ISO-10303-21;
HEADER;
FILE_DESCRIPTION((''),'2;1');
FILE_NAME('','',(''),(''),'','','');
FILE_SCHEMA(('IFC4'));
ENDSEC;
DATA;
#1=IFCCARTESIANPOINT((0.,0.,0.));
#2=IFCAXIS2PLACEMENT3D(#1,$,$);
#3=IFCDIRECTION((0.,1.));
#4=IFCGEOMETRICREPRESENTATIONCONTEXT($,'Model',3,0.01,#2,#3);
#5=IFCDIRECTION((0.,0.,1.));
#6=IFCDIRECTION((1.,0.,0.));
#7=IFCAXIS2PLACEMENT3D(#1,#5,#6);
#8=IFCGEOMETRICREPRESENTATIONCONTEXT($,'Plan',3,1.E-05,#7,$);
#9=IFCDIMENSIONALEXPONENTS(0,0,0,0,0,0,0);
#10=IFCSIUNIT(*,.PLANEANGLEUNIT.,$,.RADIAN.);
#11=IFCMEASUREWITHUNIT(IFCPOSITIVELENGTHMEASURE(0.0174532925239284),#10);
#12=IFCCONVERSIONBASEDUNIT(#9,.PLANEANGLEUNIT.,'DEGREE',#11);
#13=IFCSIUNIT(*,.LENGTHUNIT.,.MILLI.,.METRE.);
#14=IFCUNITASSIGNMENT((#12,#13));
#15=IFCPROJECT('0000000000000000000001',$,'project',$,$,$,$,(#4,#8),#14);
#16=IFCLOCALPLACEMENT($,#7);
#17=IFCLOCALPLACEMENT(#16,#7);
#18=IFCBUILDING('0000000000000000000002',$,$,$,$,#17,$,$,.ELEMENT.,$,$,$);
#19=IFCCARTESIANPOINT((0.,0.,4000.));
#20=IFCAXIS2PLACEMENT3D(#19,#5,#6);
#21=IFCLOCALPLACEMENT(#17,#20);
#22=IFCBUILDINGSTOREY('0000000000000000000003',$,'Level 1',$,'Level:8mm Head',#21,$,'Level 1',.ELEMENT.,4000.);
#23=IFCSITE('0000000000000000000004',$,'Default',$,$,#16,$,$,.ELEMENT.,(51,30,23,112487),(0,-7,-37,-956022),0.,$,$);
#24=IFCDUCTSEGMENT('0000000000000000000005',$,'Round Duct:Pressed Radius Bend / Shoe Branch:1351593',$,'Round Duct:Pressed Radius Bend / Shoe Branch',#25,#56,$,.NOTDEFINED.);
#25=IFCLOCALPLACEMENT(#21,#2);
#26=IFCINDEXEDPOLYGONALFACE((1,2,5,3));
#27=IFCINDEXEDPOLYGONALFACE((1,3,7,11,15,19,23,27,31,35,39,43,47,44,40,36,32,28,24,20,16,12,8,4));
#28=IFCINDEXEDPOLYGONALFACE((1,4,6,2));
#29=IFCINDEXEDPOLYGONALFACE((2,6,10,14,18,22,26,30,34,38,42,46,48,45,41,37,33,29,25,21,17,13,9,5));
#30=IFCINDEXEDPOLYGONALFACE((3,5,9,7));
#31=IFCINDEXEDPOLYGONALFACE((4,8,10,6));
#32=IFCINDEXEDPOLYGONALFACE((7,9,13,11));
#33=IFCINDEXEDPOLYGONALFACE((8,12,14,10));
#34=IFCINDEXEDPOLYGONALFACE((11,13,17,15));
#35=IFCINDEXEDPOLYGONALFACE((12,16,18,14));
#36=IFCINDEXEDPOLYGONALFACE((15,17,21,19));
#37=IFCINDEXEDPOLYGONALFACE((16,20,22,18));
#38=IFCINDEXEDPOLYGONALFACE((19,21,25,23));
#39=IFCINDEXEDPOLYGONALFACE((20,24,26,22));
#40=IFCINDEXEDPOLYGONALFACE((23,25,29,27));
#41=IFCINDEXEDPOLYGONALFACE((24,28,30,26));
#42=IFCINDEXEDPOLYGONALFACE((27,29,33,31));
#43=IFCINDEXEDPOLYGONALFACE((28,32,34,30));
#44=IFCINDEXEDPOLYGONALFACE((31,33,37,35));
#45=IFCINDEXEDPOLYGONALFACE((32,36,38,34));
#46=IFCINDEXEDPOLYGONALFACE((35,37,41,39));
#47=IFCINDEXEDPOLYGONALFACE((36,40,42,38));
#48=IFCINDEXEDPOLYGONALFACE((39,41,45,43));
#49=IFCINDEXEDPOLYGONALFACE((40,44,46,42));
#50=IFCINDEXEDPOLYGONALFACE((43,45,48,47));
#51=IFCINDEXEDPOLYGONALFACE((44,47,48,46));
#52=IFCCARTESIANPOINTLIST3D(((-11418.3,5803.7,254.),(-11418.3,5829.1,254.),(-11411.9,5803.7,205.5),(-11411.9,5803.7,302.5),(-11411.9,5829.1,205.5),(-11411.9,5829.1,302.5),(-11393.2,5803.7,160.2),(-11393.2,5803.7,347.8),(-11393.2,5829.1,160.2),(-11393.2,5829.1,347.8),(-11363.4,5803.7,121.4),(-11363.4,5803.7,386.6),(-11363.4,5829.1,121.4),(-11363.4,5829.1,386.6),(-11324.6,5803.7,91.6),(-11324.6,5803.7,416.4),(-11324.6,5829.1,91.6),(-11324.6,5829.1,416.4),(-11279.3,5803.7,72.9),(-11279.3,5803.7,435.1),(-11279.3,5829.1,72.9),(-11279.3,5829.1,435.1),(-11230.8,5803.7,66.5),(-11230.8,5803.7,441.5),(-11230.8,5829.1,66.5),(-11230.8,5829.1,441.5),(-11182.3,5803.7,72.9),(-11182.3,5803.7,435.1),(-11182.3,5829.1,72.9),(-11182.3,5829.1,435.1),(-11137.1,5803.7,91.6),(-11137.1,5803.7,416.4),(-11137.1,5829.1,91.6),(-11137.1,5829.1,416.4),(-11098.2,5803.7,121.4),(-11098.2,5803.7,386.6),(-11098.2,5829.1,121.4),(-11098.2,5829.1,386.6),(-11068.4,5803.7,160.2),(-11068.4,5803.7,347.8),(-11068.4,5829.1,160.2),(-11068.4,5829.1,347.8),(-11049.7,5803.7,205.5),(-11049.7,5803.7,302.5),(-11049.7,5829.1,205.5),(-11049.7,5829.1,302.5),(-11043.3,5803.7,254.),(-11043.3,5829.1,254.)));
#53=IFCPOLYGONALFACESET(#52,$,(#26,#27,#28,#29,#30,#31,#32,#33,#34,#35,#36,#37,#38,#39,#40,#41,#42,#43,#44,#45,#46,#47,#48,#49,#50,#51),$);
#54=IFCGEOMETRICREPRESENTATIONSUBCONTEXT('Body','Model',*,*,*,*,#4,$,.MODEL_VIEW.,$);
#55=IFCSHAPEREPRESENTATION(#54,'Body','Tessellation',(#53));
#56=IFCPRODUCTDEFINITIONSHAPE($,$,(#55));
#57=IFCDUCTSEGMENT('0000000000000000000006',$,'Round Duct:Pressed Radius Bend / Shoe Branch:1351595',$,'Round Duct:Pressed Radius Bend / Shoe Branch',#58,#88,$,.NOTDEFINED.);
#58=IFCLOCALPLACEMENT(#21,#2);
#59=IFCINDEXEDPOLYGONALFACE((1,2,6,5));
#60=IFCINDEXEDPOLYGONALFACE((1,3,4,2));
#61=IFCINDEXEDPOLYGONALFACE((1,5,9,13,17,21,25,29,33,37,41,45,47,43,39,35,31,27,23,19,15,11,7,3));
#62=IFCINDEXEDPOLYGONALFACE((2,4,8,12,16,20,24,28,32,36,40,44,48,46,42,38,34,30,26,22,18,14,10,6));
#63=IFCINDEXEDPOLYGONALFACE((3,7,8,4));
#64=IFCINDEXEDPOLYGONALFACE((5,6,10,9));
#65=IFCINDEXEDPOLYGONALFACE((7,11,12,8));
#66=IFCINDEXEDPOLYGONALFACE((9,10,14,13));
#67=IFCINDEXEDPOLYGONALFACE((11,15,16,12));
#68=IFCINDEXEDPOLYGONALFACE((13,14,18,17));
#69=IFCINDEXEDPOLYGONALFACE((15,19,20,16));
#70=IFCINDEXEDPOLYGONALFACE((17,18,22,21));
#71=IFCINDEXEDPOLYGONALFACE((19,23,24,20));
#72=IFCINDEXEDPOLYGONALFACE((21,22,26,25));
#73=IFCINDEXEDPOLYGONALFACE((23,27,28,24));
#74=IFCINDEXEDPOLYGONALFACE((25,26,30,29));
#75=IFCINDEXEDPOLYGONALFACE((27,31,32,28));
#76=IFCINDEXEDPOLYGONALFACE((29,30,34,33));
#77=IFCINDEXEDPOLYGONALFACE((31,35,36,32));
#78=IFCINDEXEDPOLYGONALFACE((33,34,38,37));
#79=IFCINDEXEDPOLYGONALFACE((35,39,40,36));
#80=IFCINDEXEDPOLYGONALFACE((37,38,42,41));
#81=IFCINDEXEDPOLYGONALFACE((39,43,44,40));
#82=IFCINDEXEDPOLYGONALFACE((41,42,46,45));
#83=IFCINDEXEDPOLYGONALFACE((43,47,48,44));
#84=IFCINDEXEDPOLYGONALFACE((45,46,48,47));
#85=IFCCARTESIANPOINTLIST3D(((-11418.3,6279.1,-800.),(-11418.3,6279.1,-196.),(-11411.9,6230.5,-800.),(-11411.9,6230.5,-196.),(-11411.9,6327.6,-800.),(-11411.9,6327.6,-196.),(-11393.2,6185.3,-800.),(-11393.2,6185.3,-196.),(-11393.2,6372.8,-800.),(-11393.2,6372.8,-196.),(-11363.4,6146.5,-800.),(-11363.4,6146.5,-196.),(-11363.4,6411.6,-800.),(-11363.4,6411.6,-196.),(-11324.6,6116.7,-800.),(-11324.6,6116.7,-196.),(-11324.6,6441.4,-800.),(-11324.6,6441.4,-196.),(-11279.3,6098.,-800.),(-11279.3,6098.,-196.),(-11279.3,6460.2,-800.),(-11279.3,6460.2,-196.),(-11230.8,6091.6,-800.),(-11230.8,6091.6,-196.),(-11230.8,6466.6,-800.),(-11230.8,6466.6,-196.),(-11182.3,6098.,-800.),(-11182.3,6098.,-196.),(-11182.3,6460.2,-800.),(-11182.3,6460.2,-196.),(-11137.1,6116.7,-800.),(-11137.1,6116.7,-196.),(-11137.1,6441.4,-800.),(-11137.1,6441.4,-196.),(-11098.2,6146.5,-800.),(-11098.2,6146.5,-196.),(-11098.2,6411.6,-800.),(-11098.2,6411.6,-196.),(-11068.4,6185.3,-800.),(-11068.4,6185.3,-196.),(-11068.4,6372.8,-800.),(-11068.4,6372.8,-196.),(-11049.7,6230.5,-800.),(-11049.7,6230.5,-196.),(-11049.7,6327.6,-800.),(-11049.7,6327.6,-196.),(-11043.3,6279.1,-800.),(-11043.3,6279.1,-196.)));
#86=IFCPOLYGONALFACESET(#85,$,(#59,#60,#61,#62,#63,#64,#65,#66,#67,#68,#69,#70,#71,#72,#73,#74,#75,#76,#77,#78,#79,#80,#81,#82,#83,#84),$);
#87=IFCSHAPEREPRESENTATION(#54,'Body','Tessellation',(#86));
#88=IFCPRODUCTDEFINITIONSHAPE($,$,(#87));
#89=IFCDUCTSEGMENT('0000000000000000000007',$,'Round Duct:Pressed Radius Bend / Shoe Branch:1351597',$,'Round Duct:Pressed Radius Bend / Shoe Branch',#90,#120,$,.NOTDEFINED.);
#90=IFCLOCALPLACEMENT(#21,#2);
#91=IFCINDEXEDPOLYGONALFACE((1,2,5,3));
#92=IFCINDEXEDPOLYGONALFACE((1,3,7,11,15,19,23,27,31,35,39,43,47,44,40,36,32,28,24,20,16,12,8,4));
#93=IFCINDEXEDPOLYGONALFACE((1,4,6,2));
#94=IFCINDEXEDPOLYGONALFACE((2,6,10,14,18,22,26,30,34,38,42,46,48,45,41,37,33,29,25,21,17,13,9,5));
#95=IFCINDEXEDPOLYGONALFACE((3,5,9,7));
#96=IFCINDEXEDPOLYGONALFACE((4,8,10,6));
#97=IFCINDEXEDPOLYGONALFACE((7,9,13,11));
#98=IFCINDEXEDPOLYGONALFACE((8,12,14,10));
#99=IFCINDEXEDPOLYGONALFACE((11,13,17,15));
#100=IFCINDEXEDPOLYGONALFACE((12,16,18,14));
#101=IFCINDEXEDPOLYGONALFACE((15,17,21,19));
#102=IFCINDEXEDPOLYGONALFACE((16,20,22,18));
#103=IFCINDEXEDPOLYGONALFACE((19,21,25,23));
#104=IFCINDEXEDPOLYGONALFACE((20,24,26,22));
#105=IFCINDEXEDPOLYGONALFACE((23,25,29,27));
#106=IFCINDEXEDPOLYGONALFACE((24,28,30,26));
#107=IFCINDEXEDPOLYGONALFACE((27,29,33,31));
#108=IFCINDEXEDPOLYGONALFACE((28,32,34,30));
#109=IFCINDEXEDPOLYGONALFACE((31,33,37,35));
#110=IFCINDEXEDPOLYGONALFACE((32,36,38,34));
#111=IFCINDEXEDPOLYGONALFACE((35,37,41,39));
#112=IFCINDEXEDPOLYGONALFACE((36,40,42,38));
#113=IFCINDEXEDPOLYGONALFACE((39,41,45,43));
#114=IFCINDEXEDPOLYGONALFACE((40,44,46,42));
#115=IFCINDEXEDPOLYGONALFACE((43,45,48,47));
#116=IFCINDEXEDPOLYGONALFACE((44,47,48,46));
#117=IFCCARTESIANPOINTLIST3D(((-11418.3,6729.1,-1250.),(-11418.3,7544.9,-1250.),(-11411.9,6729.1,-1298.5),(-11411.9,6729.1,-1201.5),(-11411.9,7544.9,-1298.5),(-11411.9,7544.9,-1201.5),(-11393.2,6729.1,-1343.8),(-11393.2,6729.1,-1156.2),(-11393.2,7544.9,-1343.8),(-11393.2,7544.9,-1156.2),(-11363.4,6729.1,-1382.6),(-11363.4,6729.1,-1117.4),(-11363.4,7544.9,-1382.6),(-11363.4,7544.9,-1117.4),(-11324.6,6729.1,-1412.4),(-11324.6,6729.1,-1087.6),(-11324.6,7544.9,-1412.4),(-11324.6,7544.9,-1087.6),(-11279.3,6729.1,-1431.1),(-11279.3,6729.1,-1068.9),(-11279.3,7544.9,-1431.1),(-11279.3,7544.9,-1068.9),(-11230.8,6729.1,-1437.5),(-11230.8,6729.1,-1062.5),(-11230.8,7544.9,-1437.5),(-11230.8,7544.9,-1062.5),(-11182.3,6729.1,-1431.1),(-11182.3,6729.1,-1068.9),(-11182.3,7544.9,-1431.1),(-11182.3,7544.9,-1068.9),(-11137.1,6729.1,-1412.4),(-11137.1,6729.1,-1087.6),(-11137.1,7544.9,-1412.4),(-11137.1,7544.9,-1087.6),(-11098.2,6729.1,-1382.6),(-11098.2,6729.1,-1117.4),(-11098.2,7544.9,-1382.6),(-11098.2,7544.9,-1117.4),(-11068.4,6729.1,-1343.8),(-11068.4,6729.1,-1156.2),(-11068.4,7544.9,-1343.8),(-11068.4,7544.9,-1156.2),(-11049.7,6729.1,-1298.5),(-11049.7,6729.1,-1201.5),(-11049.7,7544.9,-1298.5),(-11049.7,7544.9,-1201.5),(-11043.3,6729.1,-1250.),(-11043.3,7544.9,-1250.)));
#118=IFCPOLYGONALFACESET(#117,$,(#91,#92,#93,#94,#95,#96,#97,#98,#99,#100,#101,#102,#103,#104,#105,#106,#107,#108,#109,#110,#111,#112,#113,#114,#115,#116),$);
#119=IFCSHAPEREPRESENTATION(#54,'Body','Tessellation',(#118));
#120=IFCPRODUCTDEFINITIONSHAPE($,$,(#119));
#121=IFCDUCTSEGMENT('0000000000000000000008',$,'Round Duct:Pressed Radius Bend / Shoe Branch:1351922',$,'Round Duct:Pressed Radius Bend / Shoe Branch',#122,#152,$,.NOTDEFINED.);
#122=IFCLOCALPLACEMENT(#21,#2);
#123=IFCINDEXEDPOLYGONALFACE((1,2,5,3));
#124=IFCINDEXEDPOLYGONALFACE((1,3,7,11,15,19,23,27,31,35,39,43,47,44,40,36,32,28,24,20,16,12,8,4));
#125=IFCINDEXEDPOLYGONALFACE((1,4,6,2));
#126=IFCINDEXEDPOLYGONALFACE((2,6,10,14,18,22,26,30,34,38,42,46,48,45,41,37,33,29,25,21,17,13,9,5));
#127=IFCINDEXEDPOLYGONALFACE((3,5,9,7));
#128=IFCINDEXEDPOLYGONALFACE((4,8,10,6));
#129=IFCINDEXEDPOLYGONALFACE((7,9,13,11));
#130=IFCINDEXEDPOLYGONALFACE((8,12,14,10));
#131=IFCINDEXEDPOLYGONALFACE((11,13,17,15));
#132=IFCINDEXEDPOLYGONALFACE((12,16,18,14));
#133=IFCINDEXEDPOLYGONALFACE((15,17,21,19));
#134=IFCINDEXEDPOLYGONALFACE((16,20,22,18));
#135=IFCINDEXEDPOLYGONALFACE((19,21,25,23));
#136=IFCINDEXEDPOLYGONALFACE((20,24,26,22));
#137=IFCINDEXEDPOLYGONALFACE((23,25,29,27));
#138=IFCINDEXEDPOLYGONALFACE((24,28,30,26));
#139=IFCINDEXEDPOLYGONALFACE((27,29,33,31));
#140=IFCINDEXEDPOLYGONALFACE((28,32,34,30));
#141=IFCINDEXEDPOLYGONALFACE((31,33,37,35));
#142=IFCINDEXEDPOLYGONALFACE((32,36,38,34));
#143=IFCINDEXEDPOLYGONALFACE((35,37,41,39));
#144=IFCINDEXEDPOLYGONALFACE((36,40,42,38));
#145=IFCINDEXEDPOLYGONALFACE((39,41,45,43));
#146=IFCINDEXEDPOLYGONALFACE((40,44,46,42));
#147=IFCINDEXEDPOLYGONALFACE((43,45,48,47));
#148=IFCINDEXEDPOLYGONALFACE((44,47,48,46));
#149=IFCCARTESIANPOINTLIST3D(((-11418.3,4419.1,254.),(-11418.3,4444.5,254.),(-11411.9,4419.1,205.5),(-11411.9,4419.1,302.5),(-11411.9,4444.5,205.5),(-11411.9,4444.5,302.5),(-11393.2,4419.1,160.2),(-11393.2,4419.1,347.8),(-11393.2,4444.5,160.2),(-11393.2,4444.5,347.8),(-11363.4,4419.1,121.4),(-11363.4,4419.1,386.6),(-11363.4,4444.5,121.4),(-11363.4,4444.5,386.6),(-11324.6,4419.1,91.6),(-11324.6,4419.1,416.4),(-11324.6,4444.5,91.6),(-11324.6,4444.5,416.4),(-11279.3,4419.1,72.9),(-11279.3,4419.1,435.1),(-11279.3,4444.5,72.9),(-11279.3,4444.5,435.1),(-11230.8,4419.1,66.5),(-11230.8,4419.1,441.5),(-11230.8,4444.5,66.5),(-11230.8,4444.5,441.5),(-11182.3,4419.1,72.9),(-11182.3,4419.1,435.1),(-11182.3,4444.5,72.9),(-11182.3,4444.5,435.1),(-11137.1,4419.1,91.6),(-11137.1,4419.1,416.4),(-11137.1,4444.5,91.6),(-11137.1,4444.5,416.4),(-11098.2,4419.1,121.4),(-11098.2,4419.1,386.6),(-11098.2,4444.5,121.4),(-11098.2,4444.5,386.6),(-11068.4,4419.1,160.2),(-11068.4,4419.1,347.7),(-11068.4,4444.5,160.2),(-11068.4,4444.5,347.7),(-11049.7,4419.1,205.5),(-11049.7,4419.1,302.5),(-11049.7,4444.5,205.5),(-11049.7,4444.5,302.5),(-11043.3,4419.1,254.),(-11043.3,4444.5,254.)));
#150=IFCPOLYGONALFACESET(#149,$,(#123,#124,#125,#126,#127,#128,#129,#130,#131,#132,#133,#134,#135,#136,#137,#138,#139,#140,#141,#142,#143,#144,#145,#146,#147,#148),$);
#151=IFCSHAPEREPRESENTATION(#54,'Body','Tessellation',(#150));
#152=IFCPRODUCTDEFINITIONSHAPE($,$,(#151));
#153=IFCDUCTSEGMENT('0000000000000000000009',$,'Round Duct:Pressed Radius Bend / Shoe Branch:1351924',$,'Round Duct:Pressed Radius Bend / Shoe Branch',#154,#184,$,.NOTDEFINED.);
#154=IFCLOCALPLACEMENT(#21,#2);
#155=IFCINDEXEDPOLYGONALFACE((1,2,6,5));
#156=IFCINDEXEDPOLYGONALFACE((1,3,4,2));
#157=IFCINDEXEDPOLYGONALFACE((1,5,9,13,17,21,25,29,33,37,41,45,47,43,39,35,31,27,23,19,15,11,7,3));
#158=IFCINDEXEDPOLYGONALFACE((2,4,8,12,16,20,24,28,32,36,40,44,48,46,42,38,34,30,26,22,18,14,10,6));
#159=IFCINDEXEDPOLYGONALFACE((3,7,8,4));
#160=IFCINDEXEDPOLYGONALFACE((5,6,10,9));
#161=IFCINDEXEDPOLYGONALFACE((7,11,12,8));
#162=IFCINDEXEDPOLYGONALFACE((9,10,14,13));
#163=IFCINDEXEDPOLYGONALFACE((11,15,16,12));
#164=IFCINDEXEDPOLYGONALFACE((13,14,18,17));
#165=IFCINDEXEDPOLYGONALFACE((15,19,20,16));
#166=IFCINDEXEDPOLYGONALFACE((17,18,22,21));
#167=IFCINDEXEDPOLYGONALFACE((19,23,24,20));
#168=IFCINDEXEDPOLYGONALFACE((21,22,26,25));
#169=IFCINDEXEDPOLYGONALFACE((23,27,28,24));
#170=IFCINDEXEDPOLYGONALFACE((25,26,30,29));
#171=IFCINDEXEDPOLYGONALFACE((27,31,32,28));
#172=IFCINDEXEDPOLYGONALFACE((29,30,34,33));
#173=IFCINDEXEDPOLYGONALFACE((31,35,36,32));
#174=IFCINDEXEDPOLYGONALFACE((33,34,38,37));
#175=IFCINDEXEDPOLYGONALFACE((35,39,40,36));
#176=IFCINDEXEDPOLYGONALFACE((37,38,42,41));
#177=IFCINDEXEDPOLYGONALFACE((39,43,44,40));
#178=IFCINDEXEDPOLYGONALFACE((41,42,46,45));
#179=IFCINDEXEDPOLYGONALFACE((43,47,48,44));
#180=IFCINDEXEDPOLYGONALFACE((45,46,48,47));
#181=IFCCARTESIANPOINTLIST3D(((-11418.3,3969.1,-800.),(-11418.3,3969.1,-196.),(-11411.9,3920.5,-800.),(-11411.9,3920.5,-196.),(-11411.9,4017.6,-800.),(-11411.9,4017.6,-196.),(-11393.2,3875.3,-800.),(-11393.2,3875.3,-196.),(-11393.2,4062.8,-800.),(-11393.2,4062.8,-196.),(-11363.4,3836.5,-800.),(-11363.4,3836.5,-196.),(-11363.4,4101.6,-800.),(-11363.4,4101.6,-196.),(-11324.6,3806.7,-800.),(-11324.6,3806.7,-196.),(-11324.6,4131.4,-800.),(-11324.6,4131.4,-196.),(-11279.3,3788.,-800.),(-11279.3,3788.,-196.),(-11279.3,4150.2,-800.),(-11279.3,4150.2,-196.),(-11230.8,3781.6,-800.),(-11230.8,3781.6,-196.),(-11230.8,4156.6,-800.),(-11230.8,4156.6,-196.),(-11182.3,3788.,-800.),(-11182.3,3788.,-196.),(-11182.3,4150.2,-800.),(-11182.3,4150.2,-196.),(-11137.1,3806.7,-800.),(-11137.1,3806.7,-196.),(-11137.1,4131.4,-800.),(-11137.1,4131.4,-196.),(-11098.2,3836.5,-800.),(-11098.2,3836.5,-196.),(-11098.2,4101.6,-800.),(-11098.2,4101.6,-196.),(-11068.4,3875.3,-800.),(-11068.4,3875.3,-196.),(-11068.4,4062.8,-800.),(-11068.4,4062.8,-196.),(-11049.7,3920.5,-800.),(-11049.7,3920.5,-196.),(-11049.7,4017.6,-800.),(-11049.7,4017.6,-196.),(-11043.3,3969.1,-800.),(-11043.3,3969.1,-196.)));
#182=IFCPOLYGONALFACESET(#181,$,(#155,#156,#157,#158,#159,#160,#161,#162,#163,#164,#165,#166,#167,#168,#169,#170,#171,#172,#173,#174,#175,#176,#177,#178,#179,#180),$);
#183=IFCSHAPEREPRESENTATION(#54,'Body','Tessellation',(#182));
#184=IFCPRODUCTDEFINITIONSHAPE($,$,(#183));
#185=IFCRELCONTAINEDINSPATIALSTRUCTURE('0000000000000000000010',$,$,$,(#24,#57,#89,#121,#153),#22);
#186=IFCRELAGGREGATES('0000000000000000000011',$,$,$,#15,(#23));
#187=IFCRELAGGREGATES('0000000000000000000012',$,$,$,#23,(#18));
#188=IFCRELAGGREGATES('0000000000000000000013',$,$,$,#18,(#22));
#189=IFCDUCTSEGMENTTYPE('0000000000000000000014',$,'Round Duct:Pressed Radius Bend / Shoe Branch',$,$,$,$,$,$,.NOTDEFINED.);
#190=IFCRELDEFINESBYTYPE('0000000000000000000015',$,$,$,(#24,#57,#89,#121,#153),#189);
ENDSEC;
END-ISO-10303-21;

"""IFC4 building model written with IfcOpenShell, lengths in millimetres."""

from ifc_helpers import new_model, entity, si_unit, converted_unit, direction, frame, origin, origin_with_axes, place, context, subcontext, project, spatial, arc, indexed_curve, outline, extrude, type_object, element, save


model = new_model("IFC4")

# Units and contexts
model_context = context("Model", 3, precision=0.01, world=origin(), true_north=direction((0.0, 1.0)))
plan_context = context("Plan", 3, precision=1e-05, world=origin_with_axes())
body_context = subcontext(model_context, "Body", "Model", "MODEL_VIEW")
ifc_project = project(units=[converted_unit("PLANEANGLEUNIT", "DEGREE", entity("IfcPositiveLengthMeasure", 0.0174532925239284), si_unit("PLANEANGLEUNIT", "RADIAN"), dimensions=[0, 0, 0, 0, 0, 0, 0]), si_unit("LENGTHUNIT", "METRE", prefix="MILLI")], contexts=[model_context, plan_context])

# Site, building, storey
site_placement = place(None, origin_with_axes())
site = spatial("IfcSite", under=ifc_project, at=site_placement, Name="Default", CompositionType="ELEMENT", RefLatitude=(51, 30, 23, 112487), RefLongitude=(0, -7, -37, -956022), RefElevation=0.0)
building_placement = place(site_placement, origin_with_axes())
building = spatial("IfcBuilding", under=site, at=building_placement, CompositionType="ELEMENT")
storey_placement = place(building_placement, frame((0.0, 0.0, 4000.0), z_axis=(0.0, 0.0, 1.0), x_axis=(1.0, 0.0, 0.0)))
storey = spatial("IfcBuildingStorey", under=building, at=storey_placement, Name="Level 1", ObjectType="Level:8mm Head", LongName="Level 1", CompositionType="ELEMENT", Elevation=4000.0)

# Duct segments
duct_segment_type = type_object("IfcDuctSegmentType", Name="Round Duct:Pressed Radius Bend / Shoe Branch", PredefinedType="NOTDEFINED")
duct_segment_1_placement = place(storey_placement, origin_with_axes())
element("IfcDuctSegment", 1, at=duct_segment_1_placement, inside=storey, type_object=duct_segment_type, Name="Round Duct:Pressed Radius Bend / Shoe Branch:1351593", ObjectType="Round Duct:Pressed Radius Bend / Shoe Branch", PredefinedType="NOTDEFINED", context=body_context, shape_type="SweptSolid", body=[
    extrude(outline(indexed_curve([(187.5, 0.0), (132.6, 132.6), (0.0, 187.5), (-132.6, 132.6), (-187.5, 0.0), (-132.6, -132.6), (0.0, -187.5), (132.6, -132.6)], segments=[arc(1, 2, 3), arc(3, 4, 5), arc(5, 6, 7), arc(7, 8, 1)], self_intersect=False)), frame((-11230.8, 5803.7, 254.0), z_axis=(0.0, 1.0, 0.0), x_axis=(1.0, 0.0, 0.0)), (0.0, 0.0, 1.0), 25.4),
])
duct_segment_2_placement = place(storey_placement, origin_with_axes())
element("IfcDuctSegment", 2, at=duct_segment_2_placement, inside=storey, type_object=duct_segment_type, Name="Round Duct:Pressed Radius Bend / Shoe Branch:1351595", ObjectType="Round Duct:Pressed Radius Bend / Shoe Branch", PredefinedType="NOTDEFINED", context=body_context, shape_type="SweptSolid", body=[
    extrude(outline(indexed_curve([(187.5, 0.0), (132.6, 132.6), (0.0, 187.5), (-132.6, 132.6), (-187.5, 0.0), (-132.6, -132.6), (0.0, -187.5), (132.6, -132.6)], segments=[arc(1, 2, 3), arc(3, 4, 5), arc(5, 6, 7), arc(7, 8, 1)], self_intersect=False)), frame((-11230.8, 6279.1, -800.0)), (0.0, 0.0, 1.0), 604.0),
])
duct_segment_3_placement = place(storey_placement, origin_with_axes())
element("IfcDuctSegment", 3, at=duct_segment_3_placement, inside=storey, type_object=duct_segment_type, Name="Round Duct:Pressed Radius Bend / Shoe Branch:1351597", ObjectType="Round Duct:Pressed Radius Bend / Shoe Branch", PredefinedType="NOTDEFINED", context=body_context, shape_type="SweptSolid", body=[
    extrude(outline(indexed_curve([(187.5, 0.0), (132.6, 132.6), (0.0, 187.5), (-132.6, 132.6), (-187.5, 0.0), (-132.6, -132.6), (0.0, -187.5), (132.6, -132.6)], segments=[arc(1, 2, 3), arc(3, 4, 5), arc(5, 6, 7), arc(7, 8, 1)], self_intersect=False)), frame((-11230.8, 6729.1, -1250.0), z_axis=(0.0, 1.0, 0.0), x_axis=(-1.0, 0.0, 0.0)), (0.0, 0.0, 1.0), 815.8),
])
duct_segment_4_placement = place(storey_placement, origin_with_axes())
element("IfcDuctSegment", 4, at=duct_segment_4_placement, inside=storey, type_object=duct_segment_type, Name="Round Duct:Pressed Radius Bend / Shoe Branch:1351922", ObjectType="Round Duct:Pressed Radius Bend / Shoe Branch", PredefinedType="NOTDEFINED", context=body_context, shape_type="SweptSolid", body=[
    extrude(outline(indexed_curve([(187.5, 0.0), (132.6, 132.6), (0.0, 187.5), (-132.6, 132.6), (-187.5, 0.0), (-132.6, -132.6), (0.0, -187.5), (132.6, -132.6)], segments=[arc(1, 2, 3), arc(3, 4, 5), arc(5, 6, 7), arc(7, 8, 1)], self_intersect=False)), frame((-11230.8, 4419.1, 254.0), z_axis=(0.0, 1.0, 0.0), x_axis=(-1.0, 0.0, 0.0)), (0.0, 0.0, 1.0), 25.4),
])
duct_segment_5_placement = place(storey_placement, origin_with_axes())
element("IfcDuctSegment", 5, at=duct_segment_5_placement, inside=storey, type_object=duct_segment_type, Name="Round Duct:Pressed Radius Bend / Shoe Branch:1351924", ObjectType="Round Duct:Pressed Radius Bend / Shoe Branch", PredefinedType="NOTDEFINED", context=body_context, shape_type="SweptSolid", body=[
    extrude(outline(indexed_curve([(187.5, 0.0), (132.6, 132.6), (0.0, 187.5), (-132.6, 132.6), (-187.5, 0.0), (-132.6, -132.6), (0.0, -187.5), (132.6, -132.6)], segments=[arc(1, 2, 3), arc(3, 4, 5), arc(5, 6, 7), arc(7, 8, 1)], self_intersect=False)), frame((-11230.8, 3969.1, -800.0), z_axis=(0.0, 0.0, 1.0), x_axis=(-1.0, 0.0, 0.0)), (0.0, 0.0, 1.0), 604.0),
])

save(model, "model.ifc")
